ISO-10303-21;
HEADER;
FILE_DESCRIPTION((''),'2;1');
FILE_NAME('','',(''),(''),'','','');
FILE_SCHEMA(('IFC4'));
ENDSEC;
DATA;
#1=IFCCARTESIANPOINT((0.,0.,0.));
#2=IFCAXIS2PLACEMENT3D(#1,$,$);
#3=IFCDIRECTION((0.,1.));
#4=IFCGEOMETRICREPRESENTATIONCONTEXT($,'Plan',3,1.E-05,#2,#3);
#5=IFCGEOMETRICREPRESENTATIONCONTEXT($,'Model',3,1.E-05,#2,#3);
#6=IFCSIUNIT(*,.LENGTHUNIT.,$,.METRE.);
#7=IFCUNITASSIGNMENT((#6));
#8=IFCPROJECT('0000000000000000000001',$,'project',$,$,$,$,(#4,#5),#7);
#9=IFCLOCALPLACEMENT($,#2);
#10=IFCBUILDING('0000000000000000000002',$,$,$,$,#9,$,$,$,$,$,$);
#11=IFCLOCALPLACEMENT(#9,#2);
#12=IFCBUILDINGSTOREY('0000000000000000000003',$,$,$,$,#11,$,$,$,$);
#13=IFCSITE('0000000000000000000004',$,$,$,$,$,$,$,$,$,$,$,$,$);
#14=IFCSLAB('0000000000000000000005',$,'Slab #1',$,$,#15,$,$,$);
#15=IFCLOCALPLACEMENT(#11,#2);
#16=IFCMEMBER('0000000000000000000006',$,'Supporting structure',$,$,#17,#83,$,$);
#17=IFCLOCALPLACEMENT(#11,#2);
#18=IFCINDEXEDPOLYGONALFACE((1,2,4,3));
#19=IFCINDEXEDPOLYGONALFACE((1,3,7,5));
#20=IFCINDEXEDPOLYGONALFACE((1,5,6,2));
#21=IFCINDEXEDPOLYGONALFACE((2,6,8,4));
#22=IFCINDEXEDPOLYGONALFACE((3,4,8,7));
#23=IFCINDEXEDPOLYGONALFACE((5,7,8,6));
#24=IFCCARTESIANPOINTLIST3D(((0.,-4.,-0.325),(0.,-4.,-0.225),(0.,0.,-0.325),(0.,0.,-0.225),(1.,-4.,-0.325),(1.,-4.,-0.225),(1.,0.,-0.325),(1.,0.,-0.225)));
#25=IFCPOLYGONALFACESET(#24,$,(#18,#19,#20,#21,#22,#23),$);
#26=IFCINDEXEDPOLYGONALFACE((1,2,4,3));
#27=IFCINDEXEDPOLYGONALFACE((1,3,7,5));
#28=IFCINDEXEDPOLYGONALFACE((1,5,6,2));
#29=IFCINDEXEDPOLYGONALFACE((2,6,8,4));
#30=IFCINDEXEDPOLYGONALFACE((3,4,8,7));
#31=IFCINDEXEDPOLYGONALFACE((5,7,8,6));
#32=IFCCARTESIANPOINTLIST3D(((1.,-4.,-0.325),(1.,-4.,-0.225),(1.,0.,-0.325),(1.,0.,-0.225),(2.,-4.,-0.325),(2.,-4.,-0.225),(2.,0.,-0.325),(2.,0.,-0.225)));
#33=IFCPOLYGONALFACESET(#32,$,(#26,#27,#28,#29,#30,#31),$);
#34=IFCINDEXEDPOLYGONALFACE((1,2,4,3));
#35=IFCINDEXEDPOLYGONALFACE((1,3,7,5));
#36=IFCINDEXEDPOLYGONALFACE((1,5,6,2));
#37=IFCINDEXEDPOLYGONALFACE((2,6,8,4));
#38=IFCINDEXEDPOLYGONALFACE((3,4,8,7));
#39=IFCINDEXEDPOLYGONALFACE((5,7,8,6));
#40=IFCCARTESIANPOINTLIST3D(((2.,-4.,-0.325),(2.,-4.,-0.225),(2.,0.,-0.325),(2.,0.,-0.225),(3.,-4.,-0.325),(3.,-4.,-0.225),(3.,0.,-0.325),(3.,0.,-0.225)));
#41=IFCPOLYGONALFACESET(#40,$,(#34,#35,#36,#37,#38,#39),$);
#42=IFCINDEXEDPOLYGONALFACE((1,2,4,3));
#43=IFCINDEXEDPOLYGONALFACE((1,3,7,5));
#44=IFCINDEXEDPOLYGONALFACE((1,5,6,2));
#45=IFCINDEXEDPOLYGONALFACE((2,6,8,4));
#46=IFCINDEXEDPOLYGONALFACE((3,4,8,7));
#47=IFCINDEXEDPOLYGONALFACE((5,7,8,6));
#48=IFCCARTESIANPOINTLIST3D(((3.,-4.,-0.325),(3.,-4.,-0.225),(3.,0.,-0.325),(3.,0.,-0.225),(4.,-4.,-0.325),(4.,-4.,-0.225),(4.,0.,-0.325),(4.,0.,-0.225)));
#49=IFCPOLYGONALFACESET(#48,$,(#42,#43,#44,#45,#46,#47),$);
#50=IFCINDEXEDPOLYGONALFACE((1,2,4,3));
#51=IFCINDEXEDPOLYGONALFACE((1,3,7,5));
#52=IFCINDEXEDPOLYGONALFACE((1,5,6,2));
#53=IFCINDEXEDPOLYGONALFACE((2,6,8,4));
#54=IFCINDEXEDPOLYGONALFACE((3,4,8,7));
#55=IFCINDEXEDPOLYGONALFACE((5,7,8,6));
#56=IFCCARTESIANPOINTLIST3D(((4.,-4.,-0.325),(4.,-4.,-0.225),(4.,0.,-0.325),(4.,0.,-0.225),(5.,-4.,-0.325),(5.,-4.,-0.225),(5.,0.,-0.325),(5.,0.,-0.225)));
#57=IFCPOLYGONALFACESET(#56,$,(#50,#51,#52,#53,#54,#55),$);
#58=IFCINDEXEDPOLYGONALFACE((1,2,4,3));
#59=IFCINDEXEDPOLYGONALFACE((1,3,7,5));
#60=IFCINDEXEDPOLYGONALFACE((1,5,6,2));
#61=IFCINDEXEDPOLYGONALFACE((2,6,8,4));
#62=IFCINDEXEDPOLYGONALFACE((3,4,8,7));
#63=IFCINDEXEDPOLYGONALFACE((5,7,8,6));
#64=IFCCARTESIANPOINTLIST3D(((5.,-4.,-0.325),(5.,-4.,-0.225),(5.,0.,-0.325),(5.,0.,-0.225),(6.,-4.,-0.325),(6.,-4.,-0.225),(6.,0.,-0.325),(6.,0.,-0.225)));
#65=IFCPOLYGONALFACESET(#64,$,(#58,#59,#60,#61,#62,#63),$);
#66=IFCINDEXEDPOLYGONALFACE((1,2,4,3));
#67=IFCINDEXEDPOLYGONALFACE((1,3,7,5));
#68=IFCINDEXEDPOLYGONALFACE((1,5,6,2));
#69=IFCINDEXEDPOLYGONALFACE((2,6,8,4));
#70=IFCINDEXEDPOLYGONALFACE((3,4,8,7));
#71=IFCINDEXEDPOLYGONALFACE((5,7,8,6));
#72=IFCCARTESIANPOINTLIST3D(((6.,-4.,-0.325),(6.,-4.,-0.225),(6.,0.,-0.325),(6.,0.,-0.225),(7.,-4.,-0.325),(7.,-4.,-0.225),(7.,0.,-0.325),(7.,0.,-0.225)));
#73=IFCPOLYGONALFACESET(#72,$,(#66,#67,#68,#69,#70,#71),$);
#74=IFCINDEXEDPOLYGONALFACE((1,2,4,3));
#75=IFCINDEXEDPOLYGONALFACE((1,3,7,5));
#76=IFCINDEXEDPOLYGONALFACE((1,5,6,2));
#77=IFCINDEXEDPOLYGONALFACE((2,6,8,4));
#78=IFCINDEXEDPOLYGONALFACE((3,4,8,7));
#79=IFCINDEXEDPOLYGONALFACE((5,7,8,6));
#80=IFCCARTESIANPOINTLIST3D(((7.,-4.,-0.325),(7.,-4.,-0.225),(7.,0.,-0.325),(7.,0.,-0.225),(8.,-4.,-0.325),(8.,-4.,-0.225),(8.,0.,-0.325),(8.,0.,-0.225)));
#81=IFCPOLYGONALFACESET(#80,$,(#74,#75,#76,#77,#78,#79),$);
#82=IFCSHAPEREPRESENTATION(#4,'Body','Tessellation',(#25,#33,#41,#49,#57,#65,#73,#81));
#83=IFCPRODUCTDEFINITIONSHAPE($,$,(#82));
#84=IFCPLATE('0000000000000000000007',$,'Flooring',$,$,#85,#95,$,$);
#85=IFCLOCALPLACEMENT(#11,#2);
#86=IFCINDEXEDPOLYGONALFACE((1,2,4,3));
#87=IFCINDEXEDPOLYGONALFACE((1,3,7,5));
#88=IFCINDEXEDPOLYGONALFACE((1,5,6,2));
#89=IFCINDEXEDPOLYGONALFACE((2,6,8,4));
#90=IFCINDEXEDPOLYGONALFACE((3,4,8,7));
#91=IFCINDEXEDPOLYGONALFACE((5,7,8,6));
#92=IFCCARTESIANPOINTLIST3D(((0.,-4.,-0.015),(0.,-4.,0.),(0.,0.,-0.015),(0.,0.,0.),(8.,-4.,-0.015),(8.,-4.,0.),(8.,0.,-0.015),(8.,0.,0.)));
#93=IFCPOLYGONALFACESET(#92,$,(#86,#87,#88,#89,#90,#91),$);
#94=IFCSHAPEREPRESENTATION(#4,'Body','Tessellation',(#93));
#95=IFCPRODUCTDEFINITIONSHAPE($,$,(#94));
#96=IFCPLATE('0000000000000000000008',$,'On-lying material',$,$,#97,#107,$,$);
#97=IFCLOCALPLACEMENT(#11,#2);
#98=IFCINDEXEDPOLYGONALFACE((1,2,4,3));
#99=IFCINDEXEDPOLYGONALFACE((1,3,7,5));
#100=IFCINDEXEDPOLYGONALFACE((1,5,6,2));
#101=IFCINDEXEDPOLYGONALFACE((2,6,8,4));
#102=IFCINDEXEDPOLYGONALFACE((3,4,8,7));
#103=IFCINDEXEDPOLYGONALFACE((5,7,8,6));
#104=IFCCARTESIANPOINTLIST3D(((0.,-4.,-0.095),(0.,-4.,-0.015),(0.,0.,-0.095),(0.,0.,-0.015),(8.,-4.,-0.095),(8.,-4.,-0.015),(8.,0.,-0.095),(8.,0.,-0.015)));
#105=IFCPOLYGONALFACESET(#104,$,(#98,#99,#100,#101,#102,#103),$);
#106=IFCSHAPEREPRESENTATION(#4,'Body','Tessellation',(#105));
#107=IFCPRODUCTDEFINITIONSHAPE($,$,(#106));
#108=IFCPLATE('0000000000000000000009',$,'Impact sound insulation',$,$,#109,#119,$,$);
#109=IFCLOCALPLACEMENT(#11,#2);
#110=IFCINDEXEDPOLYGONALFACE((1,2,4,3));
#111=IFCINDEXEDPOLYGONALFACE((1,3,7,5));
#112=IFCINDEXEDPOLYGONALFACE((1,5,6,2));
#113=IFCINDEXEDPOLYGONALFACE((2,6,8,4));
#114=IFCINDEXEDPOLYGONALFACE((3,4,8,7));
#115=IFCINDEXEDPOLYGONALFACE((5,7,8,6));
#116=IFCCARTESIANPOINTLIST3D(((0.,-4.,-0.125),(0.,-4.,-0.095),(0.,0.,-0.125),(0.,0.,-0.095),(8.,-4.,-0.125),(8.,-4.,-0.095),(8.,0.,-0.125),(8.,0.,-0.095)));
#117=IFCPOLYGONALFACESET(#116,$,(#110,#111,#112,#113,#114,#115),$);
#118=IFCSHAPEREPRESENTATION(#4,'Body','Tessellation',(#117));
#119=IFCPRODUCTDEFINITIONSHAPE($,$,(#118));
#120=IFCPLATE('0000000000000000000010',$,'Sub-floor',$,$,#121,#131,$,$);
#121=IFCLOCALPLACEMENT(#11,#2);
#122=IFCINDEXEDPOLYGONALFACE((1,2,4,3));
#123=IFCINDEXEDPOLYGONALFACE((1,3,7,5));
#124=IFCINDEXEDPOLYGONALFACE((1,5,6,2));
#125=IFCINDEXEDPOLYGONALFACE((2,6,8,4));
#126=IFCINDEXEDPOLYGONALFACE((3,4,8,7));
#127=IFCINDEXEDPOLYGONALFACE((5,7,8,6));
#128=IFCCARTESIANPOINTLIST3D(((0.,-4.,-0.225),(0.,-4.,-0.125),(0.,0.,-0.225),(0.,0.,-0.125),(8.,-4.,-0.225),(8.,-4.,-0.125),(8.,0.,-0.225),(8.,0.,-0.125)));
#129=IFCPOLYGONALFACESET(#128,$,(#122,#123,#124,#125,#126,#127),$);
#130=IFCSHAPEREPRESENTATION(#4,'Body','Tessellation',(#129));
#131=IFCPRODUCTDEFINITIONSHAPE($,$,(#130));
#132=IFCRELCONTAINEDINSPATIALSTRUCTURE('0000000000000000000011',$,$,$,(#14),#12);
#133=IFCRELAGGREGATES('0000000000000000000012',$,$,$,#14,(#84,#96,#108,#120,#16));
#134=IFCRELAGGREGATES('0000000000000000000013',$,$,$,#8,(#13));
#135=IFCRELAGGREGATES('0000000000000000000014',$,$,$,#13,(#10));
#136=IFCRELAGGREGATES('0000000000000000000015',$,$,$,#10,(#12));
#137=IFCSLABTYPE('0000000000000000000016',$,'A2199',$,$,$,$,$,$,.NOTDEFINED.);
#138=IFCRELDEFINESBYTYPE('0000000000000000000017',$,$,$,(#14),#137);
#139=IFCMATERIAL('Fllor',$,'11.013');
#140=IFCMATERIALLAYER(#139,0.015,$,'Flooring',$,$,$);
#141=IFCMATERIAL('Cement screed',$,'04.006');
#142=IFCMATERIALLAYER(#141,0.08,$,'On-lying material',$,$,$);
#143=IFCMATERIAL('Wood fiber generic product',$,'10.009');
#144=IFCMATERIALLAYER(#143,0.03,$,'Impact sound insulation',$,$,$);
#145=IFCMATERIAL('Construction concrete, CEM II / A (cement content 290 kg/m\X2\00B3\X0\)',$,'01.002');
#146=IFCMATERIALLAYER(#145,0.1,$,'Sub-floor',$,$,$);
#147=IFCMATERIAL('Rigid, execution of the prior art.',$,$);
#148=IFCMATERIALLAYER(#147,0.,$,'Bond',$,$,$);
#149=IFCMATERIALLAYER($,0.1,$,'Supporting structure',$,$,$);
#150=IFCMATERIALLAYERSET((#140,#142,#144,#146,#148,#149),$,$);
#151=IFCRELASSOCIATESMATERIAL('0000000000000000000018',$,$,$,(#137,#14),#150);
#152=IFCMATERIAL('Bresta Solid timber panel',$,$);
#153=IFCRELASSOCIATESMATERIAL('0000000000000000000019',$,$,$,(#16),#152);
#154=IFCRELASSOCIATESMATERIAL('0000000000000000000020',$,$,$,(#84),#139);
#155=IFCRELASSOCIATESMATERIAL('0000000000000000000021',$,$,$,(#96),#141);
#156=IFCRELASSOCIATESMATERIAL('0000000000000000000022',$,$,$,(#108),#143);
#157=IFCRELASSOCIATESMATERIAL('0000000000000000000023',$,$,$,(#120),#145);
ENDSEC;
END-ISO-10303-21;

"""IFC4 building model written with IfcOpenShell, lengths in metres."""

from ifc_helpers import new_model, si_unit, direction, frame, frame_2d, origin, origin_with_axes, place, context, project, spatial, rectangle, extrude, material, layer, layer_set, type_object, element, aggregate, save


model = new_model("IFC4")

# Units and contexts
plan_context = context("Plan", 3, precision=1e-05, world=origin(), true_north=direction((0.0, 1.0)))
model_context = context("Model", 3, precision=1e-05, world=origin(), true_north=direction((0.0, 1.0)))
ifc_project = project(units=[si_unit("LENGTHUNIT", "METRE")], contexts=[plan_context, model_context])

# Site, building, storey
site = spatial("IfcSite", under=ifc_project)
building_placement = place(None, origin())
building = spatial("IfcBuilding", under=site, at=building_placement)
storey_placement = place(building_placement, origin())
storey = spatial("IfcBuildingStorey", under=building, at=storey_placement)

# Slab, member, plates
ifc_material_1 = material(Name="Fllor", Category="11.013")
ifc_layer_1 = layer(ifc_material_1, 0.015, Name="Flooring")
ifc_material_2 = material(Name="Cement screed", Category="04.006")
ifc_layer_2 = layer(ifc_material_2, 0.08, Name="On-lying material")
ifc_material_3 = material(Name="Wood fiber generic product", Category="10.009")
ifc_layer_3 = layer(ifc_material_3, 0.03, Name="Impact sound insulation")
ifc_material_4 = material(Name="Construction concrete, CEM II / A (cement content 290 kg/m³)", Category="01.002")
ifc_layer_4 = layer(ifc_material_4, 0.1, Name="Sub-floor")
ifc_material_5 = material(Name="Rigid, execution of the prior art.")
ifc_layer_5 = layer(ifc_material_5, 0.0, Name="Bond")
ifc_layer_6 = layer(None, 0.1, Name="Supporting structure")
ifc_layer_set = layer_set([ifc_layer_1, ifc_layer_2, ifc_layer_3, ifc_layer_4, ifc_layer_5, ifc_layer_6])
slab_type = type_object("IfcSlabType", Name="A2199", PredefinedType="NOTDEFINED", material=ifc_layer_set)
slab_placement = place(None, frame((0.0, 0.0, 0.0), z_axis=(0.0, 0.0, -1.0), x_axis=(1.0, 0.0, 0.0)))
slab = element("IfcSlab", 1, at=slab_placement, inside=storey, type_object=slab_type, material=ifc_layer_set, Name="Slab #1")
ifc_material_6 = material(Name="Bresta Solid timber panel")
member_placement = place(slab_placement, origin())
member = element("IfcMember", 2, at=member_placement, material=ifc_material_6, Name="Supporting structure", context=plan_context, shape_type="SweptSolid", body=[
    extrude(rectangle(XDim=1.0, YDim=0.1, at=frame_2d((0.5, 0.05), x_axis=(1.0, 0.0))), frame((0.0, 4.0, 0.225), z_axis=(0.0, -1.0, 0.0), x_axis=(1.0, 0.0, 0.0)), (0.0, 0.0, 1.0), 4.0),
    extrude(rectangle(XDim=1.0, YDim=0.1, at=frame_2d((0.5, 0.05), x_axis=(1.0, 0.0))), frame((1.0, 4.0, 0.225), z_axis=(0.0, -1.0, 0.0), x_axis=(1.0, 0.0, 0.0)), (0.0, 0.0, 1.0), 4.0),
    extrude(rectangle(XDim=1.0, YDim=0.1, at=frame_2d((0.5, 0.05), x_axis=(1.0, 0.0))), frame((2.0, 4.0, 0.225), z_axis=(0.0, -1.0, 0.0), x_axis=(1.0, 0.0, 0.0)), (0.0, 0.0, 1.0), 4.0),
    extrude(rectangle(XDim=1.0, YDim=0.1, at=frame_2d((0.5, 0.05), x_axis=(1.0, 0.0))), frame((3.0, 4.0, 0.225), z_axis=(0.0, -1.0, 0.0), x_axis=(1.0, 0.0, 0.0)), (0.0, 0.0, 1.0), 4.0),
    extrude(rectangle(XDim=1.0, YDim=0.1, at=frame_2d((0.5, 0.05), x_axis=(1.0, 0.0))), frame((4.0, 4.0, 0.225), z_axis=(0.0, -1.0, 0.0), x_axis=(1.0, 0.0, 0.0)), (0.0, 0.0, 1.0), 4.0),
    extrude(rectangle(XDim=1.0, YDim=0.1, at=frame_2d((0.5, 0.05), x_axis=(1.0, 0.0))), frame((5.0, 4.0, 0.225), z_axis=(0.0, -1.0, 0.0), x_axis=(1.0, 0.0, 0.0)), (0.0, 0.0, 1.0), 4.0),
    extrude(rectangle(XDim=1.0, YDim=0.1, at=frame_2d((0.5, 0.05), x_axis=(1.0, 0.0))), frame((6.0, 4.0, 0.225), z_axis=(0.0, -1.0, 0.0), x_axis=(1.0, 0.0, 0.0)), (0.0, 0.0, 1.0), 4.0),
    extrude(rectangle(XDim=1.0, YDim=0.1, at=frame_2d((0.5, 0.05), x_axis=(1.0, 0.0))), frame((7.0, 4.0, 0.225), z_axis=(0.0, -1.0, 0.0), x_axis=(1.0, 0.0, 0.0)), (0.0, 0.0, 1.0), 4.0),
])
plate_1_placement = place(slab_placement, origin())
plate_1 = element("IfcPlate", 3, at=plate_1_placement, material=ifc_material_1, Name="Flooring", context=plan_context, shape_type="SweptSolid", body=[
    extrude(rectangle(XDim=8.0, YDim=4.0, at=frame_2d((4.0, 2.0), x_axis=(1.0, 0.0))), origin_with_axes(), (0.0, 0.0, 1.0), 0.015),
])
plate_2_placement = place(slab_placement, origin())
plate_2 = element("IfcPlate", 4, at=plate_2_placement, material=ifc_material_2, Name="On-lying material", context=plan_context, shape_type="SweptSolid", body=[
    extrude(rectangle(XDim=8.0, YDim=4.0, at=frame_2d((4.0, 2.0), x_axis=(1.0, 0.0))), frame((0.0, 0.0, 0.015), z_axis=(0.0, 0.0, 1.0), x_axis=(1.0, 0.0, 0.0)), (0.0, 0.0, 1.0), 0.08),
])
plate_3_placement = place(slab_placement, origin())
plate_3 = element("IfcPlate", 5, at=plate_3_placement, material=ifc_material_3, Name="Impact sound insulation", context=plan_context, shape_type="SweptSolid", body=[
    extrude(rectangle(XDim=8.0, YDim=4.0, at=frame_2d((4.0, 2.0), x_axis=(1.0, 0.0))), frame((0.0, 0.0, 0.095), z_axis=(0.0, 0.0, 1.0), x_axis=(1.0, 0.0, 0.0)), (0.0, 0.0, 1.0), 0.03),
])
plate_4_placement = place(slab_placement, origin())
plate_4 = element("IfcPlate", 6, at=plate_4_placement, material=ifc_material_4, Name="Sub-floor", context=plan_context, shape_type="SweptSolid", body=[
    extrude(rectangle(XDim=8.0, YDim=4.0, at=frame_2d((4.0, 2.0), x_axis=(1.0, 0.0))), frame((0.0, 0.0, 0.125), z_axis=(0.0, 0.0, 1.0), x_axis=(1.0, 0.0, 0.0)), (0.0, 0.0, 1.0), 0.1),
])
aggregate(slab, [plate_1, plate_2, plate_3, plate_4, member])

save(model, "model.ifc")
